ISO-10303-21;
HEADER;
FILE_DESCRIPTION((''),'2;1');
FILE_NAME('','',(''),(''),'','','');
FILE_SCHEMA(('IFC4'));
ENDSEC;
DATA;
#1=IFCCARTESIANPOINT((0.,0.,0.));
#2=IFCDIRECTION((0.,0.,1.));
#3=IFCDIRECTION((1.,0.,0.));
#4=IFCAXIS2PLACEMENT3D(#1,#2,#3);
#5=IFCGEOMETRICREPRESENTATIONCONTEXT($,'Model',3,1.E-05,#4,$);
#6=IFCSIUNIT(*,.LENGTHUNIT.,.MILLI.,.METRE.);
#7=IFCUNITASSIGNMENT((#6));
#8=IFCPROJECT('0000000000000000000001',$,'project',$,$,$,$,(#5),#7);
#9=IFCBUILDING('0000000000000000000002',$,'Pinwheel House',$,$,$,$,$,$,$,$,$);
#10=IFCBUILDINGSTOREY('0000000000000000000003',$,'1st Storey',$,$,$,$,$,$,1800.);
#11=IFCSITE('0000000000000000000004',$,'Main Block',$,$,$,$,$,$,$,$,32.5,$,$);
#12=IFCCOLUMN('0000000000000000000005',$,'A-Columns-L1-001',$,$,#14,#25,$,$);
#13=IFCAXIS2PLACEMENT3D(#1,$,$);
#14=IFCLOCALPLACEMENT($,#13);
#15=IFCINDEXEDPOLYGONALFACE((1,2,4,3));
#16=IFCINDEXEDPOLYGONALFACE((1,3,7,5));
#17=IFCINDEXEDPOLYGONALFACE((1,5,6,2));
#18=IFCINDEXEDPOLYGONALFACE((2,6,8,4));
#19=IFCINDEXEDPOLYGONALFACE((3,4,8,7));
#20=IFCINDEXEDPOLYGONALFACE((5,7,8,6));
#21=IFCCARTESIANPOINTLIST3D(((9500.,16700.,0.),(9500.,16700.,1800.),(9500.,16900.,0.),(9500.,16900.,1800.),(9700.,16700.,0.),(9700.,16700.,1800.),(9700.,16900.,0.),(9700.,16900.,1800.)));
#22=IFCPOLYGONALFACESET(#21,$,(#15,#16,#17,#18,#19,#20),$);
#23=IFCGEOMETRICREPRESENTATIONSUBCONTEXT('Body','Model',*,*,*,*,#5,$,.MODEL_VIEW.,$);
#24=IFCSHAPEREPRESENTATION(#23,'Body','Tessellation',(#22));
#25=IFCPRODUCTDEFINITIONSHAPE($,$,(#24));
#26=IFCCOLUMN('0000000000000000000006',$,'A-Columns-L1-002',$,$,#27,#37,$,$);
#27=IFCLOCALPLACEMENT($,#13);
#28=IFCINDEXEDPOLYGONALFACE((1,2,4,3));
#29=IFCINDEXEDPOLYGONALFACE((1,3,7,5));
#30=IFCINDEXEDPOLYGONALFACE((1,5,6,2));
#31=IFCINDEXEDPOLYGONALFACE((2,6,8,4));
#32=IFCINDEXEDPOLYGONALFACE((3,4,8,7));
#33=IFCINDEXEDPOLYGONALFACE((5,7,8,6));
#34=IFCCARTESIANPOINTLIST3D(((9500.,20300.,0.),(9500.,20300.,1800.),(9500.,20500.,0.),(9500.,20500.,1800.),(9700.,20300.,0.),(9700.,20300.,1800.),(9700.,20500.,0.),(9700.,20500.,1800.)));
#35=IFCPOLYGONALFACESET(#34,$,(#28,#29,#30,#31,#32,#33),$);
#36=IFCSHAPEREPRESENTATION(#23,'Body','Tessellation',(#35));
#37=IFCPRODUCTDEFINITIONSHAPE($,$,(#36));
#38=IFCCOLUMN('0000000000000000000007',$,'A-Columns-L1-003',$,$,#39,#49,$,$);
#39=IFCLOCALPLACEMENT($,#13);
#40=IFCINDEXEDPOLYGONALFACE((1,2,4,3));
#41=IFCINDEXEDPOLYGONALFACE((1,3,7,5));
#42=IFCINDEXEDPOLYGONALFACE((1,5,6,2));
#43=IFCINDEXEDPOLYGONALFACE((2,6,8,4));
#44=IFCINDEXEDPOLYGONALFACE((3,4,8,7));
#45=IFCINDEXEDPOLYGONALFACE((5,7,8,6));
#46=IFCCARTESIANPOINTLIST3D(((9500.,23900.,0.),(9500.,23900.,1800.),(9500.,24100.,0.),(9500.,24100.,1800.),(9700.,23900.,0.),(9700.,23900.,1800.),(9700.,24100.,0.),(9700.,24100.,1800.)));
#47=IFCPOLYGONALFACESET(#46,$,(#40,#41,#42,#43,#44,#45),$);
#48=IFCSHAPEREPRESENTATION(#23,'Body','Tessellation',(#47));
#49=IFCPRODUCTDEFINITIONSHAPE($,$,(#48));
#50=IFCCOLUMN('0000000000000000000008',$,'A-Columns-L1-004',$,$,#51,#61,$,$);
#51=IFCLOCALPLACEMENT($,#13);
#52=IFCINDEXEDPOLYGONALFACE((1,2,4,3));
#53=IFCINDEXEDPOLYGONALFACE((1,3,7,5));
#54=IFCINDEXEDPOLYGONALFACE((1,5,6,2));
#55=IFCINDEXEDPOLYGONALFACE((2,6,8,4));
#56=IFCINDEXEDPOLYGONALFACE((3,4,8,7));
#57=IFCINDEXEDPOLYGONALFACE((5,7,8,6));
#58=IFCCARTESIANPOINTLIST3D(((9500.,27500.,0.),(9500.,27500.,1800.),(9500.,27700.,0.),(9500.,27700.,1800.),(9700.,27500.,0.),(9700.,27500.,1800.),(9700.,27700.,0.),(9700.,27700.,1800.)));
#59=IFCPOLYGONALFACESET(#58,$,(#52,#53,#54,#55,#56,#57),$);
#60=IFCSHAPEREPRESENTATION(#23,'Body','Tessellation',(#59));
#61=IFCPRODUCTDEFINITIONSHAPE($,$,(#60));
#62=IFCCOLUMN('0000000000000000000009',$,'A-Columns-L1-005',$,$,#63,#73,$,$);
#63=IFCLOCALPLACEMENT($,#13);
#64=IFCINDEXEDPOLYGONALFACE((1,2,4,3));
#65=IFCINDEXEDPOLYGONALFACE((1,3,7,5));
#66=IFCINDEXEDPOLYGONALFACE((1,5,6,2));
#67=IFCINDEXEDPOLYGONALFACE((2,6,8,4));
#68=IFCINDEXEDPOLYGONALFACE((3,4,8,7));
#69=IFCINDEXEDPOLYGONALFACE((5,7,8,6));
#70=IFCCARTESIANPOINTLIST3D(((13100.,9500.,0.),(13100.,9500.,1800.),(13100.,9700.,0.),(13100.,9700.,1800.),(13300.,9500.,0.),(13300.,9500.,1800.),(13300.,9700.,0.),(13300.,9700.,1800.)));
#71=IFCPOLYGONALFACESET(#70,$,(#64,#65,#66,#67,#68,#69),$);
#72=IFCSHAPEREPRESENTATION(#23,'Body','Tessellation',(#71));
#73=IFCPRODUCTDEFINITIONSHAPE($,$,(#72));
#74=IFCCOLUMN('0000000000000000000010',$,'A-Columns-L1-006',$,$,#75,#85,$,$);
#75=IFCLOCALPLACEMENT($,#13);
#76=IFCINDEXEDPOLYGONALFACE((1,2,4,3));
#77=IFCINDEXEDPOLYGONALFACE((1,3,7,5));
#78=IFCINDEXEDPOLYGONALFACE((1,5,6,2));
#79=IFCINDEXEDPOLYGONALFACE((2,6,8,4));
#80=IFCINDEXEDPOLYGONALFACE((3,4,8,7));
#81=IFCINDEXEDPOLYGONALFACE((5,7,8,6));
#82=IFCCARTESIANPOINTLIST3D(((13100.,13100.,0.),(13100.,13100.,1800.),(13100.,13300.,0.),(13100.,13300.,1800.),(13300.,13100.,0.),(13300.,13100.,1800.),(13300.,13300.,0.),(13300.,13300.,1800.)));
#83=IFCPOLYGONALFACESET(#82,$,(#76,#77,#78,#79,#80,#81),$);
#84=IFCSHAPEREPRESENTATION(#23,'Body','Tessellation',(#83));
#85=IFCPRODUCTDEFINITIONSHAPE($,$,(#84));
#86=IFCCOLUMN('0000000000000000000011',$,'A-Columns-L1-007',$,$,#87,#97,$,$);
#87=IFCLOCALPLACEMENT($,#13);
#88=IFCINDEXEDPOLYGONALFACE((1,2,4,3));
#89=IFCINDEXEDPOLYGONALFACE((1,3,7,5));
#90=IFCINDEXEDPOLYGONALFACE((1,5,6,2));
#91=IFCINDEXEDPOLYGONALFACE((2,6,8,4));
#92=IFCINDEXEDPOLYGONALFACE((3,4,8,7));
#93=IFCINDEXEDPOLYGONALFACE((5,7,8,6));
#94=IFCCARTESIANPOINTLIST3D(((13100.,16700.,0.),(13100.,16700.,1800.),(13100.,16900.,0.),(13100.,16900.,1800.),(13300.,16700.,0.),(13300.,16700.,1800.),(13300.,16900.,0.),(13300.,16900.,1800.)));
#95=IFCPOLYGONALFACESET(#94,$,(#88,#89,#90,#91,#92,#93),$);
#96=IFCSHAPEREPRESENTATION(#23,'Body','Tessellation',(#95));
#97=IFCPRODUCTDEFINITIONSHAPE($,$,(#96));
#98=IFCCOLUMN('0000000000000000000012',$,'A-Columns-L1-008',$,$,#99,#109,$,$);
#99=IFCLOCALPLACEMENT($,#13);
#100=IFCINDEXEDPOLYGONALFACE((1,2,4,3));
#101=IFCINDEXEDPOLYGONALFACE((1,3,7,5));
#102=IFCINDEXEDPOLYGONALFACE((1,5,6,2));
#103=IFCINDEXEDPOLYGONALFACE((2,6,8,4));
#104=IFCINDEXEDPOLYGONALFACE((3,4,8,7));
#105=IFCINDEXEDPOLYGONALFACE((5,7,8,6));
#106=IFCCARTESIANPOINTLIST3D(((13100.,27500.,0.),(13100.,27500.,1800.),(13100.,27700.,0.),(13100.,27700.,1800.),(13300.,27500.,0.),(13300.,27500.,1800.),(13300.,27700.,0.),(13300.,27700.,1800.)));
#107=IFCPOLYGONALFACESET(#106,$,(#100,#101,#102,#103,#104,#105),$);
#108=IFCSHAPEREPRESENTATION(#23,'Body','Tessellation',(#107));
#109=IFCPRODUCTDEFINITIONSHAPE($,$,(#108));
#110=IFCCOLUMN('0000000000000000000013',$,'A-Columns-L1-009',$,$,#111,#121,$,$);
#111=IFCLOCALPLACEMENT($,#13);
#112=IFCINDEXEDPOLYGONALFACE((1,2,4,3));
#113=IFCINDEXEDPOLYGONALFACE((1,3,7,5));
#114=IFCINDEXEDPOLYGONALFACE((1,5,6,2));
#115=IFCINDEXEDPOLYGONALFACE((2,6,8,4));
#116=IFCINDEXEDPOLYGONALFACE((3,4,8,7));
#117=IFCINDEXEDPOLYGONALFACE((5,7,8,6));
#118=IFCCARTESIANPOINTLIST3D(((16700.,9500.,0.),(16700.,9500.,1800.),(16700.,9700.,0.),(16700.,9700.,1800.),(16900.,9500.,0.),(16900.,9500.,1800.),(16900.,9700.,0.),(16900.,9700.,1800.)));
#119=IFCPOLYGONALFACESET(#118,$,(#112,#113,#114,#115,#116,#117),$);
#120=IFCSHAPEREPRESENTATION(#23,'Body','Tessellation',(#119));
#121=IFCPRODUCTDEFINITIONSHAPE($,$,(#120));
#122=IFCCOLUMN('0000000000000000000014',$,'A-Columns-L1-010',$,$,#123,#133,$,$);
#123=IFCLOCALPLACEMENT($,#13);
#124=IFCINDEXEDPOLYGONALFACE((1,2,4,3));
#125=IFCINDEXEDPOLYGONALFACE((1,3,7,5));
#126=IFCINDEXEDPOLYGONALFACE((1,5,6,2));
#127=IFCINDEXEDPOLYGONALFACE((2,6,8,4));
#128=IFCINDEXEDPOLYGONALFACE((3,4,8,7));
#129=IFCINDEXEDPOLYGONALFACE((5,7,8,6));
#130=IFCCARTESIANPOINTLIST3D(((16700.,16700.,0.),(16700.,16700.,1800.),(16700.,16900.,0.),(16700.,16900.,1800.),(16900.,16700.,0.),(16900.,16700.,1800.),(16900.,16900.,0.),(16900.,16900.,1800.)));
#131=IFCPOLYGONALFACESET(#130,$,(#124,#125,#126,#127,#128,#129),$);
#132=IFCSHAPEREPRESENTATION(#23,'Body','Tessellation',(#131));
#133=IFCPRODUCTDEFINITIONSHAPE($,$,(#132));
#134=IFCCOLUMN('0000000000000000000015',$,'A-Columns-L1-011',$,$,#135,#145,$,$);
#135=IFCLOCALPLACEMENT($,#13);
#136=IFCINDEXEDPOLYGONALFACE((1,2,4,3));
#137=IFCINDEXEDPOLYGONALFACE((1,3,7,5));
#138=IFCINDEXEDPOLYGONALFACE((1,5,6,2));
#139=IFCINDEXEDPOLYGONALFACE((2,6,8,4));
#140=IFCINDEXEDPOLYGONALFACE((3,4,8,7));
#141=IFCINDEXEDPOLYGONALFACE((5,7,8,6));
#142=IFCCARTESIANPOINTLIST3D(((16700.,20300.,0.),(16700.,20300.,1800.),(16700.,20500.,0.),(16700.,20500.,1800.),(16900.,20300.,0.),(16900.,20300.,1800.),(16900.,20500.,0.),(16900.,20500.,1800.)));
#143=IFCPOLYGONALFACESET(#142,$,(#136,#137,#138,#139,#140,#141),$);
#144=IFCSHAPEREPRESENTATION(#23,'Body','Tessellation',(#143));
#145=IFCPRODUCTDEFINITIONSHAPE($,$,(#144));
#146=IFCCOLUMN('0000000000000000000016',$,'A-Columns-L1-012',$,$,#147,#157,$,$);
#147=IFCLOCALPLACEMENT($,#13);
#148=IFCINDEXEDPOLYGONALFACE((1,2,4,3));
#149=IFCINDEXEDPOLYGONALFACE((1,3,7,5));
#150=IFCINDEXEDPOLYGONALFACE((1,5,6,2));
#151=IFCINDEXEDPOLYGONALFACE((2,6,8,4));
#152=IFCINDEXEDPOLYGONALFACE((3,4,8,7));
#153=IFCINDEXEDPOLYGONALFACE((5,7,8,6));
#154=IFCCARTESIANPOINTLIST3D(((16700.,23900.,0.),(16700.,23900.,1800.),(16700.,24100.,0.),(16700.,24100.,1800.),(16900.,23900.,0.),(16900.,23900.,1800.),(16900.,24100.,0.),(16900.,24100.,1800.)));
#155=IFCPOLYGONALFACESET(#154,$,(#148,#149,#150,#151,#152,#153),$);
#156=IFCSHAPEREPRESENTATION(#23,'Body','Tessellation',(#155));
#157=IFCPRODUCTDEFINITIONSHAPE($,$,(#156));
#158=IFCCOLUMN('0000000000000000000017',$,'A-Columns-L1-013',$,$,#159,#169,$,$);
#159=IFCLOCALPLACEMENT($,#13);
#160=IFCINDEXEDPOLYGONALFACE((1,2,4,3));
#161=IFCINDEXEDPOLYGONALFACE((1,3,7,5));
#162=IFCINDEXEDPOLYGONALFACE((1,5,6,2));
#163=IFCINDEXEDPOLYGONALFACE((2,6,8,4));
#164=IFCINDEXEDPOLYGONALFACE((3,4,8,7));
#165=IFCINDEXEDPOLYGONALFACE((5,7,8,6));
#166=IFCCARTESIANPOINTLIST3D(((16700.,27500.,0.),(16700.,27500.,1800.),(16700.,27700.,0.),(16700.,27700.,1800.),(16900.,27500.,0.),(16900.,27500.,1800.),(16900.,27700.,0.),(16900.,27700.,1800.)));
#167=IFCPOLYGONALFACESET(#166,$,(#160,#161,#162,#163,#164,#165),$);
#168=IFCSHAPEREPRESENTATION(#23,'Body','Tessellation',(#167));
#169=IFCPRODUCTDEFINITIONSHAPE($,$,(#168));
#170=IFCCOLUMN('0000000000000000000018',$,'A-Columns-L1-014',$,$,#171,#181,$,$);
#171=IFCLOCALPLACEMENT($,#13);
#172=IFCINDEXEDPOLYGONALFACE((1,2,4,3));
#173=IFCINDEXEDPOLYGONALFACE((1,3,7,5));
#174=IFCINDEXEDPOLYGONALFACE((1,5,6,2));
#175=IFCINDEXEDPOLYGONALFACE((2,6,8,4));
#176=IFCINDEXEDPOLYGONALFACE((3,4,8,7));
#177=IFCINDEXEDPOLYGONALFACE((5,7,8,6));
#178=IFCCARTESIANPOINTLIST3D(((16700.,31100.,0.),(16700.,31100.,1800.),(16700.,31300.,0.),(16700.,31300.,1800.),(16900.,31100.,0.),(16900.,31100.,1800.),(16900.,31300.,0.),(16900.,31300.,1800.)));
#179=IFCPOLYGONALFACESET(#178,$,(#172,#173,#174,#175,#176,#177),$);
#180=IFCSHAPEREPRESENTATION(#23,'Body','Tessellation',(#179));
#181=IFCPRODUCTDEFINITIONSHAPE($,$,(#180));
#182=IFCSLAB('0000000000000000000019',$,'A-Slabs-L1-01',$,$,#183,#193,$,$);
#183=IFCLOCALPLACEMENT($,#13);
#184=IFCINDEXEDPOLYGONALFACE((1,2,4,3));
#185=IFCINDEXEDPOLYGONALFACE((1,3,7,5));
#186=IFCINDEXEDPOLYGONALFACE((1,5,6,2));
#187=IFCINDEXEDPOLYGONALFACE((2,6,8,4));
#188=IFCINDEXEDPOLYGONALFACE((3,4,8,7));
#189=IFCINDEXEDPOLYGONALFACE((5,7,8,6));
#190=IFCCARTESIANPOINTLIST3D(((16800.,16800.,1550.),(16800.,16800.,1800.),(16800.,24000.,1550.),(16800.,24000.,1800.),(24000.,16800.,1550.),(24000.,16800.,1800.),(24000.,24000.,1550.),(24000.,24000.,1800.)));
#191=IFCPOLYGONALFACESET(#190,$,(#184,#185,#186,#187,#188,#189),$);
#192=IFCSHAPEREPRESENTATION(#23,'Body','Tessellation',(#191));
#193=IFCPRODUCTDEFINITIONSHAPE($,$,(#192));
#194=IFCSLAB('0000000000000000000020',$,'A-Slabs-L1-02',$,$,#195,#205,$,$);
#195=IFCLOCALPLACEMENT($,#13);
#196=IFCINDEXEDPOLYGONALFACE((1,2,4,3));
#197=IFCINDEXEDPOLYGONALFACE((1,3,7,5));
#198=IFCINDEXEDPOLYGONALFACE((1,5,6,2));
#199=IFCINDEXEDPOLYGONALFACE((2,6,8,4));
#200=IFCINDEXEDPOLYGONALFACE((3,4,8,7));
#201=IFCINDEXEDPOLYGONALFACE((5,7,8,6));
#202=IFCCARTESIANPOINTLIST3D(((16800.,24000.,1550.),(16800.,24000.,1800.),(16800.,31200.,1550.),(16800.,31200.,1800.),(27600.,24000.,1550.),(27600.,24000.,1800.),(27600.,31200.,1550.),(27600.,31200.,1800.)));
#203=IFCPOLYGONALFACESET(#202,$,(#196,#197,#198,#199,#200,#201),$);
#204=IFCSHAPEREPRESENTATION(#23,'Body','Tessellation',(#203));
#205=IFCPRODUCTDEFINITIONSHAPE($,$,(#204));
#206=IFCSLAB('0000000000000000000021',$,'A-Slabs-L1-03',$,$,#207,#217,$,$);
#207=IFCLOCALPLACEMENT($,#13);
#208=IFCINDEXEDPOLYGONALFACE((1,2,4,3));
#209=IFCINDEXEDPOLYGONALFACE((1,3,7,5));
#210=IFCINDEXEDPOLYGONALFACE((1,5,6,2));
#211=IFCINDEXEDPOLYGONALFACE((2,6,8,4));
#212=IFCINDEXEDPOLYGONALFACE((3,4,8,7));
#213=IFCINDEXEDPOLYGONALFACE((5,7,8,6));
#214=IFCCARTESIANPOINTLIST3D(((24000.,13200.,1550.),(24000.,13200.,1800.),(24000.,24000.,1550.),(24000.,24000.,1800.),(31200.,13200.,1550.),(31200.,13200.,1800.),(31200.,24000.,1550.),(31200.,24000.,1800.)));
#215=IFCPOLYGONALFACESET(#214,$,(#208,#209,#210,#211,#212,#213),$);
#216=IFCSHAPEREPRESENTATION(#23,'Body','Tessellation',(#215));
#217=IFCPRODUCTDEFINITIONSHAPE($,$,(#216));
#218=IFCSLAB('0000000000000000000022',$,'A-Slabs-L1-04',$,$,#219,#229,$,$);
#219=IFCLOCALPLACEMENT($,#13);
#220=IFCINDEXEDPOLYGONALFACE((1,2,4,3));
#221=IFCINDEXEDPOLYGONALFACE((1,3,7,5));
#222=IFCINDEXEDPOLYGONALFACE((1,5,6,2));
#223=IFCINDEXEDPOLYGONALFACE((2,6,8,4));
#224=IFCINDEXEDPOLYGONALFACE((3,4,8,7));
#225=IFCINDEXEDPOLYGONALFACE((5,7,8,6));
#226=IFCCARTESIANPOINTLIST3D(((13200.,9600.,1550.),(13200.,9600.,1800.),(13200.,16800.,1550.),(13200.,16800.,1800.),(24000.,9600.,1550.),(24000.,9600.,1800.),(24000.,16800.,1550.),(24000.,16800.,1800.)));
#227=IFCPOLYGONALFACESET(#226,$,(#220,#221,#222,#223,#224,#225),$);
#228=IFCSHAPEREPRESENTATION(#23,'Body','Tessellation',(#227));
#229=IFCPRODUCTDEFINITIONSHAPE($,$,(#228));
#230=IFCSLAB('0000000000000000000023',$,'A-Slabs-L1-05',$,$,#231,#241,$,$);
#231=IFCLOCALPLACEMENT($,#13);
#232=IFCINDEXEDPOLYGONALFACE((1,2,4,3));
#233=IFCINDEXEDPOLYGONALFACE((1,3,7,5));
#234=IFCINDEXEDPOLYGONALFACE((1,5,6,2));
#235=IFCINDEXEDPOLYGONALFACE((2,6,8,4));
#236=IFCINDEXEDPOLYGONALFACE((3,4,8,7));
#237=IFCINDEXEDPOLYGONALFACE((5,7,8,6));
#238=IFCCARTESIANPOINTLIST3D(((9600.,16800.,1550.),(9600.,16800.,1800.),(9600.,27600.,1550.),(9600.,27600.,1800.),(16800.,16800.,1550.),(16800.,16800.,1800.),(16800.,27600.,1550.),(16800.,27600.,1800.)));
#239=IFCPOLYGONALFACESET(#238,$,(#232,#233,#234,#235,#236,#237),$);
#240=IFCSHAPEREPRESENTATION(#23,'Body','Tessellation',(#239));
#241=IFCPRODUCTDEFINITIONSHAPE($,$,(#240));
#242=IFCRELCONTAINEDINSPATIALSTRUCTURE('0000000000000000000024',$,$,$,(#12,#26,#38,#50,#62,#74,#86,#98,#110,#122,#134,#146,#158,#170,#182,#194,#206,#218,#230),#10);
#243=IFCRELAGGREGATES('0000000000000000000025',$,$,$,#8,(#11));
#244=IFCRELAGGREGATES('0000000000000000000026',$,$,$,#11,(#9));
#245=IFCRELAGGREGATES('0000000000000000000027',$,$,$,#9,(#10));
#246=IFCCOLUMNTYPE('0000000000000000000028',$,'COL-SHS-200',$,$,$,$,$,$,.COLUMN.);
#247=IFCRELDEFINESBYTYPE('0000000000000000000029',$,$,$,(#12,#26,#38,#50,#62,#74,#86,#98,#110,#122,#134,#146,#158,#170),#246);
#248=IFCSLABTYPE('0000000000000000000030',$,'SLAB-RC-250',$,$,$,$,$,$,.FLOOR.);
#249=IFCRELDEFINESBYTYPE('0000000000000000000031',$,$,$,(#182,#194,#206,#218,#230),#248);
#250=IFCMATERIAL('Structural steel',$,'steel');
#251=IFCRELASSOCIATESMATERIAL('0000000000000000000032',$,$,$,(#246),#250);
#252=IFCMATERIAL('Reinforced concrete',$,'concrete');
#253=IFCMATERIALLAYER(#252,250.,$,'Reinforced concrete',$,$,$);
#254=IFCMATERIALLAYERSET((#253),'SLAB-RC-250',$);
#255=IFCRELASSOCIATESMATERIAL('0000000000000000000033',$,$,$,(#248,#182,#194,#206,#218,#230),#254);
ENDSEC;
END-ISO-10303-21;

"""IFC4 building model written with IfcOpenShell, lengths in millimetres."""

from ifc_helpers import new_model, si_unit, frame, origin_with_axes, place, context, subcontext, project, spatial, indexed_curve, outline, extrude, material, layer, layer_set, layer_usage, type_object, element, save


model = new_model("IFC4")

# Units and contexts
model_context = context("Model", 3, precision=1e-05, world=origin_with_axes())
body_context = subcontext(model_context, "Body", "Model", "MODEL_VIEW")
ifc_project = project(units=[si_unit("LENGTHUNIT", "METRE", prefix="MILLI")], contexts=[model_context])

# Site, building, storey
site = spatial("IfcSite", under=ifc_project, Name="Main Block", RefElevation=32.5)
building = spatial("IfcBuilding", under=site, Name="Pinwheel House")
storey = spatial("IfcBuildingStorey", under=building, Name="1st Storey", Elevation=1800.0)

# Columns
ifc_material_1 = material(Name="Structural steel", Category="steel")
column_type = type_object("IfcColumnType", Name="COL-SHS-200", PredefinedType="COLUMN", material=ifc_material_1)
for number, where, z_axis, x_axis, name in (
    (1, (9600.0, 16800.0, 0.0), (0.0, 0.0, 1.0), (1.0, 0.0, 0.0), "A-Columns-L1-001"),
    (2, (9600.0, 20400.0, 0.0), (0.0, 0.0, 1.0), (1.0, 0.0, 0.0), "A-Columns-L1-002"),
    (3, (9600.0, 24000.0, 0.0), (0.0, 0.0, 1.0), (1.0, 0.0, 0.0), "A-Columns-L1-003"),
    (4, (9600.0, 27600.0, 0.0), (0.0, 0.0, 1.0), (1.0, 0.0, 0.0), "A-Columns-L1-004"),
    (5, (13200.0, 9600.0, 0.0), (0.0, 0.0, 1.0), (1.0, 0.0, 0.0), "A-Columns-L1-005"),
    (6, (13200.0, 13200.0, 0.0), (0.0, 0.0, 1.0), (1.0, 0.0, 0.0), "A-Columns-L1-006"),
    (7, (13200.0, 16800.0, 0.0), (0.0, 0.0, 1.0), (1.0, 0.0, 0.0), "A-Columns-L1-007"),
    (8, (13200.0, 27600.0, 0.0), (0.0, 0.0, 1.0), (1.0, 0.0, 0.0), "A-Columns-L1-008"),
    (9, (16800.0, 9600.0, 0.0), (0.0, 0.0, 1.0), (1.0, 0.0, 0.0), "A-Columns-L1-009"),
    (10, (16800.0, 16800.0, 0.0), (0.0, 0.0, 1.0), (1.0, 0.0, 0.0), "A-Columns-L1-010"),
    (11, (16800.0, 20400.0, 0.0), (0.0, 0.0, 1.0), (1.0, 0.0, 0.0), "A-Columns-L1-011"),
    (12, (16800.0, 24000.0, 0.0), (0.0, 0.0, 1.0), (1.0, 0.0, 0.0), "A-Columns-L1-012"),
    (13, (16800.0, 27600.0, 0.0), (0.0, 0.0, 1.0), (1.0, 0.0, 0.0), "A-Columns-L1-013"),
    (14, (16800.0, 31200.0, 0.0), (0.0, 0.0, 1.0), (1.0, 0.0, 0.0), "A-Columns-L1-014"),
):
    element("IfcColumn", number, at=place(None, frame(where, z_axis=z_axis, x_axis=x_axis)), inside=storey, type_object=column_type, Name=name, context=body_context, shape_type="SweptSolid", body=[
        extrude(outline(indexed_curve([(-100.0, -100.0), (100.0, -100.0), (100.0, 100.0), (-100.0, 100.0)])), None, (0.0, 0.0, 1.0), 1800.0),
    ])

# Slabs
ifc_material_2 = material(Name="Reinforced concrete", Category="concrete")
ifc_layer_1 = layer(ifc_material_2, 250.0, Name="Reinforced concrete")
ifc_layer_set_1 = layer_set([ifc_layer_1], Name="SLAB-RC-250")
ifc_layer_usage_1 = layer_usage(ifc_layer_set_1, "AXIS3", "POSITIVE", 0.0)
slab_type = type_object("IfcSlabType", Name="SLAB-RC-250", PredefinedType="FLOOR", material=ifc_layer_set_1)
slab_1_placement = place(None, frame((0.0, 0.0, 1550.0), z_axis=(0.0, 0.0, 1.0), x_axis=(1.0, 0.0, 0.0)))
element("IfcSlab", 15, at=slab_1_placement, inside=storey, type_object=slab_type, material=ifc_layer_usage_1, Name="A-Slabs-L1-01", context=body_context, shape_type="SweptSolid", body=[
    extrude(outline(indexed_curve([(16800.0, 16800.0), (24000.0, 16800.0), (24000.0, 24000.0), (16800.0, 24000.0)])), None, (0.0, 0.0, 1.0), 250.0),
])
ifc_layer_usage_2 = layer_usage(ifc_layer_set_1, "AXIS3", "POSITIVE", 0.0)
slab_2_placement = place(None, frame((0.0, 0.0, 1550.0), z_axis=(0.0, 0.0, 1.0), x_axis=(1.0, 0.0, 0.0)))
element("IfcSlab", 16, at=slab_2_placement, inside=storey, type_object=slab_type, material=ifc_layer_usage_2, Name="A-Slabs-L1-02", context=body_context, shape_type="SweptSolid", body=[
    extrude(outline(indexed_curve([(16800.0, 24000.0), (27600.0, 24000.0), (27600.0, 31200.0), (16800.0, 31200.0)])), None, (0.0, 0.0, 1.0), 250.0),
])
ifc_layer_usage_3 = layer_usage(ifc_layer_set_1, "AXIS3", "POSITIVE", 0.0)
slab_3_placement = place(None, frame((0.0, 0.0, 1550.0), z_axis=(0.0, 0.0, 1.0), x_axis=(1.0, 0.0, 0.0)))
element("IfcSlab", 17, at=slab_3_placement, inside=storey, type_object=slab_type, material=ifc_layer_usage_3, Name="A-Slabs-L1-03", context=body_context, shape_type="SweptSolid", body=[
    extrude(outline(indexed_curve([(24000.0, 13200.0), (31200.0, 13200.0), (31200.0, 24000.0), (24000.0, 24000.0)])), None, (0.0, 0.0, 1.0), 250.0),
])
ifc_layer_usage_4 = layer_usage(ifc_layer_set_1, "AXIS3", "POSITIVE", 0.0)
slab_4_placement = place(None, frame((0.0, 0.0, 1550.0), z_axis=(0.0, 0.0, 1.0), x_axis=(1.0, 0.0, 0.0)))
element("IfcSlab", 18, at=slab_4_placement, inside=storey, type_object=slab_type, material=ifc_layer_usage_4, Name="A-Slabs-L1-04", context=body_context, shape_type="SweptSolid", body=[
    extrude(outline(indexed_curve([(13200.0, 9600.0), (24000.0, 9600.0), (24000.0, 16800.0), (13200.0, 16800.0)])), None, (0.0, 0.0, 1.0), 250.0),
])
ifc_layer_usage_5 = layer_usage(ifc_layer_set_1, "AXIS3", "POSITIVE", 0.0)
slab_5_placement = place(None, frame((0.0, 0.0, 1550.0), z_axis=(0.0, 0.0, 1.0), x_axis=(1.0, 0.0, 0.0)))
element("IfcSlab", 19, at=slab_5_placement, inside=storey, type_object=slab_type, material=ifc_layer_usage_5, Name="A-Slabs-L1-05", context=body_context, shape_type="SweptSolid", body=[
    extrude(outline(indexed_curve([(9600.0, 16800.0), (16800.0, 16800.0), (16800.0, 27600.0), (9600.0, 27600.0)])), None, (0.0, 0.0, 1.0), 250.0),
])

save(model, "model.ifc")
